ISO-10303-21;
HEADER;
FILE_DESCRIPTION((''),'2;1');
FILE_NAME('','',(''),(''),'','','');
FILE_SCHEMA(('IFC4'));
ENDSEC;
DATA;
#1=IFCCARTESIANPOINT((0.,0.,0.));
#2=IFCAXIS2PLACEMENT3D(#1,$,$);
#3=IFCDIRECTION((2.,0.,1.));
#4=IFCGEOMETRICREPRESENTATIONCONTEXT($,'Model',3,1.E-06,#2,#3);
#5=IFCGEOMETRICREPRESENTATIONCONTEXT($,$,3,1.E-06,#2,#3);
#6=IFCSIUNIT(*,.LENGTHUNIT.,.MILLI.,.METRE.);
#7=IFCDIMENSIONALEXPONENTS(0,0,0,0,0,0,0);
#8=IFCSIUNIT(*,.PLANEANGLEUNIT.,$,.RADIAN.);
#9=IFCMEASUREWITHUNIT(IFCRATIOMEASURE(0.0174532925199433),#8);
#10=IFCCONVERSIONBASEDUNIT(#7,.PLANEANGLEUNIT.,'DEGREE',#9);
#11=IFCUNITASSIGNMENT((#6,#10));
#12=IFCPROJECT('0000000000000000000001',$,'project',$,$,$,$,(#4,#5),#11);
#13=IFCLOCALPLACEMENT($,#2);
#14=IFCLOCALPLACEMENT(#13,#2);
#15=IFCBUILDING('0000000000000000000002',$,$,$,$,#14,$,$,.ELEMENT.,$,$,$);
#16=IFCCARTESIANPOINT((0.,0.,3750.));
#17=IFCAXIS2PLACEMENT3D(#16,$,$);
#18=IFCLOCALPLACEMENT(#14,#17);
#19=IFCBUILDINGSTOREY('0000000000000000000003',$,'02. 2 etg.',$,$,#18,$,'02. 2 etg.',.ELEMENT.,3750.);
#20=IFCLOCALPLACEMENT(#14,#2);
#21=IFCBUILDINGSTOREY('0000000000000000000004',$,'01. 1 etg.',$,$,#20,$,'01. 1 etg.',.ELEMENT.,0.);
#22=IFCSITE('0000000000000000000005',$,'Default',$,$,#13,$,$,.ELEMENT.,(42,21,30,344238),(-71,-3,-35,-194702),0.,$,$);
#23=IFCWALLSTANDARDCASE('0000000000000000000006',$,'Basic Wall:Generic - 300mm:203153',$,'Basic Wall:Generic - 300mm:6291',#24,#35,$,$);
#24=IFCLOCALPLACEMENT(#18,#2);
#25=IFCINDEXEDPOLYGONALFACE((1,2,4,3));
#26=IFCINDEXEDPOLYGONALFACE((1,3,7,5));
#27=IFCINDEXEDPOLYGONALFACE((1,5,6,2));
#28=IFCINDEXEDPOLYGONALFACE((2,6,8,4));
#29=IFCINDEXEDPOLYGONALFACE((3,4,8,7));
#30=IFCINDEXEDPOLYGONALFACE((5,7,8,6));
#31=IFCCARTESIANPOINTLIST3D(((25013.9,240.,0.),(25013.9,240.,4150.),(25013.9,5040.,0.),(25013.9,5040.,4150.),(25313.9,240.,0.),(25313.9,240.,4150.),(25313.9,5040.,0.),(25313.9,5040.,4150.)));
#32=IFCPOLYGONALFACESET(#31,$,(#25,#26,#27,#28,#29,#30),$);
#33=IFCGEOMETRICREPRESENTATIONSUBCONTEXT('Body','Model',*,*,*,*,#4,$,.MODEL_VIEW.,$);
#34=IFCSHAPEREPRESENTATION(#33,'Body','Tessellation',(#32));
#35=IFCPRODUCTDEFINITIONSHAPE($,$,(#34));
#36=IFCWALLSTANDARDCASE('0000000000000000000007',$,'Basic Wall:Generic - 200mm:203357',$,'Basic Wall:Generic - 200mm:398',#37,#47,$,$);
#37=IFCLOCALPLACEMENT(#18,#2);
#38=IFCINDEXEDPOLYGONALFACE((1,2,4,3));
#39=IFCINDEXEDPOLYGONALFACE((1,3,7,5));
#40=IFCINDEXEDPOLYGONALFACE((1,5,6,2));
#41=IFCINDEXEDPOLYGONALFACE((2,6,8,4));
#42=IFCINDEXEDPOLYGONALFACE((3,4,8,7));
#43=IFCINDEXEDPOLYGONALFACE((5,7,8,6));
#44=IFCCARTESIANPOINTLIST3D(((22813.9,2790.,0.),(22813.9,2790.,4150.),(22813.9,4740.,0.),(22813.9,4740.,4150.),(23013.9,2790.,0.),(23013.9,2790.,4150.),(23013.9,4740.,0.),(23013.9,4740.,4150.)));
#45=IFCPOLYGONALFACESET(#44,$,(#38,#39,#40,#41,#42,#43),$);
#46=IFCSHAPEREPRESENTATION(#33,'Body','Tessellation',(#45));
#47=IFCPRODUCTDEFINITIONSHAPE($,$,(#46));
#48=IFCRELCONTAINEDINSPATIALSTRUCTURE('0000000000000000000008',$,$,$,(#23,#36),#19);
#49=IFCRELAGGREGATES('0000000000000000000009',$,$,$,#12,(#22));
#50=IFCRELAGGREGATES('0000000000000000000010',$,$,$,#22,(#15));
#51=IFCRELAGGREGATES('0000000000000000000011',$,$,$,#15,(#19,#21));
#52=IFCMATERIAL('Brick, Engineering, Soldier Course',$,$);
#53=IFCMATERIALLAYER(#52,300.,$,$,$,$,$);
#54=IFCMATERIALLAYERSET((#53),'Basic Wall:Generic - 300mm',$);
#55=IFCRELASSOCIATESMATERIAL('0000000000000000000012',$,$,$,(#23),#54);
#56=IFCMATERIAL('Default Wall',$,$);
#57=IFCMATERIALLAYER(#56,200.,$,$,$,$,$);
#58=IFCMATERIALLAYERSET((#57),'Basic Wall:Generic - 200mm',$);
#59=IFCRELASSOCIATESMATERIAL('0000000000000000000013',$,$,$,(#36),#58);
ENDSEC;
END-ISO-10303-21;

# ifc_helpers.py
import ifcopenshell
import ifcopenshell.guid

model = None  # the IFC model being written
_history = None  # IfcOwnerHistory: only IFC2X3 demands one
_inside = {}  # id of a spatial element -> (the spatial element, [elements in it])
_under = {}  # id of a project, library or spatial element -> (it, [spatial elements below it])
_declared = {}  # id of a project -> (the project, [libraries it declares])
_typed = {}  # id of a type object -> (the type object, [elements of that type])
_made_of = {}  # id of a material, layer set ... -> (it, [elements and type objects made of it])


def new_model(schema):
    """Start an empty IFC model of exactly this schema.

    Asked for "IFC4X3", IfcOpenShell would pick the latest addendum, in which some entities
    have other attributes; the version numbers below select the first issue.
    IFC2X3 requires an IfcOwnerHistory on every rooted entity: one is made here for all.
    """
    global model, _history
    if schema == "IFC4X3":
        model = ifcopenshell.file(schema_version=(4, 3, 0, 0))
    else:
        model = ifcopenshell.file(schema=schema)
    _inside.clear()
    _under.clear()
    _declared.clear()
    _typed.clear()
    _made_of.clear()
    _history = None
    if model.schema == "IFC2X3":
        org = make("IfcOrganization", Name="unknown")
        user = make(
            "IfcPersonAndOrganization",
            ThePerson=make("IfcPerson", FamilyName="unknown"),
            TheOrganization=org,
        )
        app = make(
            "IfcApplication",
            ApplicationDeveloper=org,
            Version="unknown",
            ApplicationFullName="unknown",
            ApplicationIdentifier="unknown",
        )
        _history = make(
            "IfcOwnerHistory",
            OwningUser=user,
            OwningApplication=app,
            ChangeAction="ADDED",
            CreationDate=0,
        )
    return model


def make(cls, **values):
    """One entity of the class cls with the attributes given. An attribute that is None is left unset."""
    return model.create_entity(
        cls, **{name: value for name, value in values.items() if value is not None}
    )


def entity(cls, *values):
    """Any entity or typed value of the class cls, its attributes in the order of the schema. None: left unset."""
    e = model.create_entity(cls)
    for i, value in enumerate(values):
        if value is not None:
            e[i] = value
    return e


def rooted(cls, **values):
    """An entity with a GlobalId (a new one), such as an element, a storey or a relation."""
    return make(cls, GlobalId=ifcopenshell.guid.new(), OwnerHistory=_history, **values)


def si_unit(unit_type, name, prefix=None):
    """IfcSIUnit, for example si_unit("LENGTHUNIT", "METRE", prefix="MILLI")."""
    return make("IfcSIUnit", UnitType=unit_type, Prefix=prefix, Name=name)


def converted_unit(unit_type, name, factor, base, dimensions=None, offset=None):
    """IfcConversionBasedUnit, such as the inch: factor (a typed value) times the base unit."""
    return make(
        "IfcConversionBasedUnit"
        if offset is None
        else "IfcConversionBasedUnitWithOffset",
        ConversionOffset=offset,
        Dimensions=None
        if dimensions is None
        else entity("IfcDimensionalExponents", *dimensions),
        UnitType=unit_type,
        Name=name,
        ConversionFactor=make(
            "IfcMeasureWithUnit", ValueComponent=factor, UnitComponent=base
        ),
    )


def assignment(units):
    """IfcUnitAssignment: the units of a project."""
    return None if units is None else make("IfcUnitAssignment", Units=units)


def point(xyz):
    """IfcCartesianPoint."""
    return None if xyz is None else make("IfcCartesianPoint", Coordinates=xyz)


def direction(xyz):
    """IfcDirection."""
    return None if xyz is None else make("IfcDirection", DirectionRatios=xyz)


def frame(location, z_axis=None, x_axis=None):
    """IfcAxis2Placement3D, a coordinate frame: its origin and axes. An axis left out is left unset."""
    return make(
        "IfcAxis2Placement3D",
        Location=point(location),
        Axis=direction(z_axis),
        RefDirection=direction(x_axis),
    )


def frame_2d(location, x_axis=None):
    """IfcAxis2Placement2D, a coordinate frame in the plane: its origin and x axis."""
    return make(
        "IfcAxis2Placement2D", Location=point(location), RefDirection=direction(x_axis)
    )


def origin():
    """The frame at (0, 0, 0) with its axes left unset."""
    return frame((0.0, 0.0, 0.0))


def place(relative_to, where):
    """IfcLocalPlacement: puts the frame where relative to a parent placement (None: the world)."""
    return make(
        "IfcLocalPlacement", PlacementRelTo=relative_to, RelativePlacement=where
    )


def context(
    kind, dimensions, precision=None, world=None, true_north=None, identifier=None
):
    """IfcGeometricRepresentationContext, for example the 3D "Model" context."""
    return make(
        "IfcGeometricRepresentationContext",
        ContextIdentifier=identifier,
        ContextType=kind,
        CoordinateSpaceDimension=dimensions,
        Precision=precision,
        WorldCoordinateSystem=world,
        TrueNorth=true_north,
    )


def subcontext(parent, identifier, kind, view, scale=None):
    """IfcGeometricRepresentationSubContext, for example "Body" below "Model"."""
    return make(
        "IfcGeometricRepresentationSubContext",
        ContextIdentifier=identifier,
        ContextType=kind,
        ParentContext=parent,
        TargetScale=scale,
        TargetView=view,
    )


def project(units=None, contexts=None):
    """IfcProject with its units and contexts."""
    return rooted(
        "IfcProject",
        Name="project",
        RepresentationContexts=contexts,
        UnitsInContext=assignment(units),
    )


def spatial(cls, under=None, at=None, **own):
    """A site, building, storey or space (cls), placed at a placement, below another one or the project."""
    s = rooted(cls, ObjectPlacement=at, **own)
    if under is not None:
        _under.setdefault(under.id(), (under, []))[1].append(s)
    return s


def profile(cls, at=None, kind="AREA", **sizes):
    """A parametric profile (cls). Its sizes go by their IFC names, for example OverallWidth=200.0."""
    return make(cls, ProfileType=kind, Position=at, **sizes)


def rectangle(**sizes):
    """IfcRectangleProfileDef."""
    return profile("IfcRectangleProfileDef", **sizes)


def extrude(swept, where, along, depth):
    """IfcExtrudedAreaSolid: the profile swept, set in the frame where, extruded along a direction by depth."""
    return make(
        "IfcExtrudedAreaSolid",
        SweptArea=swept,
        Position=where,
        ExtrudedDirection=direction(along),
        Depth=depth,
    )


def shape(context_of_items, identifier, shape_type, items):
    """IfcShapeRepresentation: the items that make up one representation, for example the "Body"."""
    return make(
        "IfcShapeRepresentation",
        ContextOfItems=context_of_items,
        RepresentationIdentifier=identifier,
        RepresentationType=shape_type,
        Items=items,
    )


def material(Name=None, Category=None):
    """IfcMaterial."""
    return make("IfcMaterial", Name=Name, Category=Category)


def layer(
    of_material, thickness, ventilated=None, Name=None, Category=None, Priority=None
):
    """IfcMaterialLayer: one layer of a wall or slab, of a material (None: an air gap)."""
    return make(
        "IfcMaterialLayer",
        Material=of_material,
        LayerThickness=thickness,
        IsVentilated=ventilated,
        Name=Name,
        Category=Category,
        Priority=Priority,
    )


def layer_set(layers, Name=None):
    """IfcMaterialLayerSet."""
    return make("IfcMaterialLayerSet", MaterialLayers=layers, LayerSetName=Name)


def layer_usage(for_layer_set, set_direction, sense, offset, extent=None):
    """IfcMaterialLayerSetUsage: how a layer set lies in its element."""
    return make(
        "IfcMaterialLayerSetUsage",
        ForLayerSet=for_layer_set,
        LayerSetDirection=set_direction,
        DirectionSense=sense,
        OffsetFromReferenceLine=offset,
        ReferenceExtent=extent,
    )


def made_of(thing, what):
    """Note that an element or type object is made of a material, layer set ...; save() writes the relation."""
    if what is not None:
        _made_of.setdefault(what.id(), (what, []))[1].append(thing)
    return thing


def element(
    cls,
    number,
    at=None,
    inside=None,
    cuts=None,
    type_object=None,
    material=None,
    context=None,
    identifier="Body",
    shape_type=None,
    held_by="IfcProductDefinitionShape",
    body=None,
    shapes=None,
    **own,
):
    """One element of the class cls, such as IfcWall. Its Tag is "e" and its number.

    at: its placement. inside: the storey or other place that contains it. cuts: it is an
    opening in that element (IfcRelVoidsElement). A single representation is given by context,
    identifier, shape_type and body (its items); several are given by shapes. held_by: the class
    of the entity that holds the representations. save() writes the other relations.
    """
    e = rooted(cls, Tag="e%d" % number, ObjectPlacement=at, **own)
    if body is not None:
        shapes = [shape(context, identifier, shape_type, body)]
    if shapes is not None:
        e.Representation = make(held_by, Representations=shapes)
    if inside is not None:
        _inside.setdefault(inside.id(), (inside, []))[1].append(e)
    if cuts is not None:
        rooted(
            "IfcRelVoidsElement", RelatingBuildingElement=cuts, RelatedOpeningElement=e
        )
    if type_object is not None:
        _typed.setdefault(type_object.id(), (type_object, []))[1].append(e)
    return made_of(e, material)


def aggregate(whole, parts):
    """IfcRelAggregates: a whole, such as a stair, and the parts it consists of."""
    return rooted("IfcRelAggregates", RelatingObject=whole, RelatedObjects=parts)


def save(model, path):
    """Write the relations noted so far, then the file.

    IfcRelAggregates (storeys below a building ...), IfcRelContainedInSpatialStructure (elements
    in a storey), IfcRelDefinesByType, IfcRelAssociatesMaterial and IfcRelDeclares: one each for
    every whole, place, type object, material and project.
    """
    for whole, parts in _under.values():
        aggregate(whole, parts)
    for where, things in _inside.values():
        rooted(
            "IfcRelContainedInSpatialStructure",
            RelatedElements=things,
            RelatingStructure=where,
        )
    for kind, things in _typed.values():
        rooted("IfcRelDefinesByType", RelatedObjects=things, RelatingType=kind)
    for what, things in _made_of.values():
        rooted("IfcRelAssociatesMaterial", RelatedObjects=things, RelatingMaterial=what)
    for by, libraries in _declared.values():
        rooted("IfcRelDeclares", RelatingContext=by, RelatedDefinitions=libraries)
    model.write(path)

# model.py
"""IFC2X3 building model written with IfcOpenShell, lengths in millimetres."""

from ifc_helpers import new_model, entity, si_unit, converted_unit, direction, frame, frame_2d, origin, place, context, subcontext, project, spatial, rectangle, extrude, material, layer, layer_set, layer_usage, element, save


model = new_model("IFC2X3")

# Units and contexts
model_context = context("Model", 3, precision=1e-06, world=origin(), true_north=direction((2.0, 0.0, 1.0)))
context_of_model = context(None, 3, precision=1e-06, world=origin(), true_north=direction((2.0, 0.0, 1.0)))
body_context = subcontext(model_context, "Body", "Model", "MODEL_VIEW")
ifc_project = project(units=[si_unit("LENGTHUNIT", "METRE", prefix="MILLI"), converted_unit("PLANEANGLEUNIT", "DEGREE", entity("IfcRatioMeasure", 0.0174532925199433), si_unit("PLANEANGLEUNIT", "RADIAN"), dimensions=[0, 0, 0, 0, 0, 0, 0])], contexts=[model_context, context_of_model])

# Site, building, storey
site_placement = place(None, origin())
site = spatial("IfcSite", under=ifc_project, at=site_placement, Name="Default", CompositionType="ELEMENT", RefLatitude=(42, 21, 30, 344238), RefLongitude=(-71, -3, -35, -194702), RefElevation=0.0)
building_placement = place(site_placement, origin())
building = spatial("IfcBuilding", under=site, at=building_placement, CompositionType="ELEMENT")
storey_1_placement = place(building_placement, frame((0.0, 0.0, 3750.0)))
storey_1 = spatial("IfcBuildingStorey", under=building, at=storey_1_placement, Name="02. 2 etg.", LongName="02. 2 etg.", CompositionType="ELEMENT", Elevation=3750.0)

# Shared definitions
storey_2_placement = place(building_placement, origin())

# Walls
ifc_material_1 = material(Name="Brick, Engineering, Soldier Course")
ifc_layer_1 = layer(ifc_material_1, 300.0)
ifc_layer_set_1 = layer_set([ifc_layer_1], Name="Basic Wall:Generic - 300mm")
ifc_layer_usage_1 = layer_usage(ifc_layer_set_1, "AXIS2", "NEGATIVE", 150.0)
wall_1_placement = place(storey_1_placement, frame((25163.9, 5040.0, 0.0), z_axis=(0.0, 0.0, 1.0), x_axis=(0.0, -1.0, 0.0)))
element("IfcWallStandardCase", 1, at=wall_1_placement, inside=storey_1, material=ifc_layer_usage_1, Name="Basic Wall:Generic - 300mm:203153", ObjectType="Basic Wall:Generic - 300mm:6291", context=body_context, shape_type="SweptSolid", body=[
    extrude(rectangle(XDim=4800.0, YDim=300.0, at=frame_2d((2400.0, 0.0), x_axis=(-1.0, 0.0))), origin(), (0.0, 0.0, 1.0), 4150.0),
])
ifc_material_2 = material(Name="Default Wall")
ifc_layer_2 = layer(ifc_material_2, 200.0)
ifc_layer_set_2 = layer_set([ifc_layer_2], Name="Basic Wall:Generic - 200mm")
ifc_layer_usage_2 = layer_usage(ifc_layer_set_2, "AXIS2", "NEGATIVE", 100.0)
wall_2_placement = place(storey_1_placement, frame((22913.9, 4740.0, 0.0), z_axis=(0.0, 0.0, 1.0), x_axis=(0.0, -1.0, 0.0)))
element("IfcWallStandardCase", 2, at=wall_2_placement, inside=storey_1, material=ifc_layer_usage_2, Name="Basic Wall:Generic - 200mm:203357", ObjectType="Basic Wall:Generic - 200mm:398", context=body_context, shape_type="SweptSolid", body=[
    extrude(rectangle(XDim=1950.0, YDim=200.0, at=frame_2d((975.0, 0.0), x_axis=(-1.0, 0.0))), origin(), (0.0, 0.0, 1.0), 4150.0),
])

# Shared definitions
storey_2 = spatial("IfcBuildingStorey", under=building, at=storey_2_placement, Name="01. 1 etg.", LongName="01. 1 etg.", CompositionType="ELEMENT", Elevation=0.0)

save(model, "model.ifc")
